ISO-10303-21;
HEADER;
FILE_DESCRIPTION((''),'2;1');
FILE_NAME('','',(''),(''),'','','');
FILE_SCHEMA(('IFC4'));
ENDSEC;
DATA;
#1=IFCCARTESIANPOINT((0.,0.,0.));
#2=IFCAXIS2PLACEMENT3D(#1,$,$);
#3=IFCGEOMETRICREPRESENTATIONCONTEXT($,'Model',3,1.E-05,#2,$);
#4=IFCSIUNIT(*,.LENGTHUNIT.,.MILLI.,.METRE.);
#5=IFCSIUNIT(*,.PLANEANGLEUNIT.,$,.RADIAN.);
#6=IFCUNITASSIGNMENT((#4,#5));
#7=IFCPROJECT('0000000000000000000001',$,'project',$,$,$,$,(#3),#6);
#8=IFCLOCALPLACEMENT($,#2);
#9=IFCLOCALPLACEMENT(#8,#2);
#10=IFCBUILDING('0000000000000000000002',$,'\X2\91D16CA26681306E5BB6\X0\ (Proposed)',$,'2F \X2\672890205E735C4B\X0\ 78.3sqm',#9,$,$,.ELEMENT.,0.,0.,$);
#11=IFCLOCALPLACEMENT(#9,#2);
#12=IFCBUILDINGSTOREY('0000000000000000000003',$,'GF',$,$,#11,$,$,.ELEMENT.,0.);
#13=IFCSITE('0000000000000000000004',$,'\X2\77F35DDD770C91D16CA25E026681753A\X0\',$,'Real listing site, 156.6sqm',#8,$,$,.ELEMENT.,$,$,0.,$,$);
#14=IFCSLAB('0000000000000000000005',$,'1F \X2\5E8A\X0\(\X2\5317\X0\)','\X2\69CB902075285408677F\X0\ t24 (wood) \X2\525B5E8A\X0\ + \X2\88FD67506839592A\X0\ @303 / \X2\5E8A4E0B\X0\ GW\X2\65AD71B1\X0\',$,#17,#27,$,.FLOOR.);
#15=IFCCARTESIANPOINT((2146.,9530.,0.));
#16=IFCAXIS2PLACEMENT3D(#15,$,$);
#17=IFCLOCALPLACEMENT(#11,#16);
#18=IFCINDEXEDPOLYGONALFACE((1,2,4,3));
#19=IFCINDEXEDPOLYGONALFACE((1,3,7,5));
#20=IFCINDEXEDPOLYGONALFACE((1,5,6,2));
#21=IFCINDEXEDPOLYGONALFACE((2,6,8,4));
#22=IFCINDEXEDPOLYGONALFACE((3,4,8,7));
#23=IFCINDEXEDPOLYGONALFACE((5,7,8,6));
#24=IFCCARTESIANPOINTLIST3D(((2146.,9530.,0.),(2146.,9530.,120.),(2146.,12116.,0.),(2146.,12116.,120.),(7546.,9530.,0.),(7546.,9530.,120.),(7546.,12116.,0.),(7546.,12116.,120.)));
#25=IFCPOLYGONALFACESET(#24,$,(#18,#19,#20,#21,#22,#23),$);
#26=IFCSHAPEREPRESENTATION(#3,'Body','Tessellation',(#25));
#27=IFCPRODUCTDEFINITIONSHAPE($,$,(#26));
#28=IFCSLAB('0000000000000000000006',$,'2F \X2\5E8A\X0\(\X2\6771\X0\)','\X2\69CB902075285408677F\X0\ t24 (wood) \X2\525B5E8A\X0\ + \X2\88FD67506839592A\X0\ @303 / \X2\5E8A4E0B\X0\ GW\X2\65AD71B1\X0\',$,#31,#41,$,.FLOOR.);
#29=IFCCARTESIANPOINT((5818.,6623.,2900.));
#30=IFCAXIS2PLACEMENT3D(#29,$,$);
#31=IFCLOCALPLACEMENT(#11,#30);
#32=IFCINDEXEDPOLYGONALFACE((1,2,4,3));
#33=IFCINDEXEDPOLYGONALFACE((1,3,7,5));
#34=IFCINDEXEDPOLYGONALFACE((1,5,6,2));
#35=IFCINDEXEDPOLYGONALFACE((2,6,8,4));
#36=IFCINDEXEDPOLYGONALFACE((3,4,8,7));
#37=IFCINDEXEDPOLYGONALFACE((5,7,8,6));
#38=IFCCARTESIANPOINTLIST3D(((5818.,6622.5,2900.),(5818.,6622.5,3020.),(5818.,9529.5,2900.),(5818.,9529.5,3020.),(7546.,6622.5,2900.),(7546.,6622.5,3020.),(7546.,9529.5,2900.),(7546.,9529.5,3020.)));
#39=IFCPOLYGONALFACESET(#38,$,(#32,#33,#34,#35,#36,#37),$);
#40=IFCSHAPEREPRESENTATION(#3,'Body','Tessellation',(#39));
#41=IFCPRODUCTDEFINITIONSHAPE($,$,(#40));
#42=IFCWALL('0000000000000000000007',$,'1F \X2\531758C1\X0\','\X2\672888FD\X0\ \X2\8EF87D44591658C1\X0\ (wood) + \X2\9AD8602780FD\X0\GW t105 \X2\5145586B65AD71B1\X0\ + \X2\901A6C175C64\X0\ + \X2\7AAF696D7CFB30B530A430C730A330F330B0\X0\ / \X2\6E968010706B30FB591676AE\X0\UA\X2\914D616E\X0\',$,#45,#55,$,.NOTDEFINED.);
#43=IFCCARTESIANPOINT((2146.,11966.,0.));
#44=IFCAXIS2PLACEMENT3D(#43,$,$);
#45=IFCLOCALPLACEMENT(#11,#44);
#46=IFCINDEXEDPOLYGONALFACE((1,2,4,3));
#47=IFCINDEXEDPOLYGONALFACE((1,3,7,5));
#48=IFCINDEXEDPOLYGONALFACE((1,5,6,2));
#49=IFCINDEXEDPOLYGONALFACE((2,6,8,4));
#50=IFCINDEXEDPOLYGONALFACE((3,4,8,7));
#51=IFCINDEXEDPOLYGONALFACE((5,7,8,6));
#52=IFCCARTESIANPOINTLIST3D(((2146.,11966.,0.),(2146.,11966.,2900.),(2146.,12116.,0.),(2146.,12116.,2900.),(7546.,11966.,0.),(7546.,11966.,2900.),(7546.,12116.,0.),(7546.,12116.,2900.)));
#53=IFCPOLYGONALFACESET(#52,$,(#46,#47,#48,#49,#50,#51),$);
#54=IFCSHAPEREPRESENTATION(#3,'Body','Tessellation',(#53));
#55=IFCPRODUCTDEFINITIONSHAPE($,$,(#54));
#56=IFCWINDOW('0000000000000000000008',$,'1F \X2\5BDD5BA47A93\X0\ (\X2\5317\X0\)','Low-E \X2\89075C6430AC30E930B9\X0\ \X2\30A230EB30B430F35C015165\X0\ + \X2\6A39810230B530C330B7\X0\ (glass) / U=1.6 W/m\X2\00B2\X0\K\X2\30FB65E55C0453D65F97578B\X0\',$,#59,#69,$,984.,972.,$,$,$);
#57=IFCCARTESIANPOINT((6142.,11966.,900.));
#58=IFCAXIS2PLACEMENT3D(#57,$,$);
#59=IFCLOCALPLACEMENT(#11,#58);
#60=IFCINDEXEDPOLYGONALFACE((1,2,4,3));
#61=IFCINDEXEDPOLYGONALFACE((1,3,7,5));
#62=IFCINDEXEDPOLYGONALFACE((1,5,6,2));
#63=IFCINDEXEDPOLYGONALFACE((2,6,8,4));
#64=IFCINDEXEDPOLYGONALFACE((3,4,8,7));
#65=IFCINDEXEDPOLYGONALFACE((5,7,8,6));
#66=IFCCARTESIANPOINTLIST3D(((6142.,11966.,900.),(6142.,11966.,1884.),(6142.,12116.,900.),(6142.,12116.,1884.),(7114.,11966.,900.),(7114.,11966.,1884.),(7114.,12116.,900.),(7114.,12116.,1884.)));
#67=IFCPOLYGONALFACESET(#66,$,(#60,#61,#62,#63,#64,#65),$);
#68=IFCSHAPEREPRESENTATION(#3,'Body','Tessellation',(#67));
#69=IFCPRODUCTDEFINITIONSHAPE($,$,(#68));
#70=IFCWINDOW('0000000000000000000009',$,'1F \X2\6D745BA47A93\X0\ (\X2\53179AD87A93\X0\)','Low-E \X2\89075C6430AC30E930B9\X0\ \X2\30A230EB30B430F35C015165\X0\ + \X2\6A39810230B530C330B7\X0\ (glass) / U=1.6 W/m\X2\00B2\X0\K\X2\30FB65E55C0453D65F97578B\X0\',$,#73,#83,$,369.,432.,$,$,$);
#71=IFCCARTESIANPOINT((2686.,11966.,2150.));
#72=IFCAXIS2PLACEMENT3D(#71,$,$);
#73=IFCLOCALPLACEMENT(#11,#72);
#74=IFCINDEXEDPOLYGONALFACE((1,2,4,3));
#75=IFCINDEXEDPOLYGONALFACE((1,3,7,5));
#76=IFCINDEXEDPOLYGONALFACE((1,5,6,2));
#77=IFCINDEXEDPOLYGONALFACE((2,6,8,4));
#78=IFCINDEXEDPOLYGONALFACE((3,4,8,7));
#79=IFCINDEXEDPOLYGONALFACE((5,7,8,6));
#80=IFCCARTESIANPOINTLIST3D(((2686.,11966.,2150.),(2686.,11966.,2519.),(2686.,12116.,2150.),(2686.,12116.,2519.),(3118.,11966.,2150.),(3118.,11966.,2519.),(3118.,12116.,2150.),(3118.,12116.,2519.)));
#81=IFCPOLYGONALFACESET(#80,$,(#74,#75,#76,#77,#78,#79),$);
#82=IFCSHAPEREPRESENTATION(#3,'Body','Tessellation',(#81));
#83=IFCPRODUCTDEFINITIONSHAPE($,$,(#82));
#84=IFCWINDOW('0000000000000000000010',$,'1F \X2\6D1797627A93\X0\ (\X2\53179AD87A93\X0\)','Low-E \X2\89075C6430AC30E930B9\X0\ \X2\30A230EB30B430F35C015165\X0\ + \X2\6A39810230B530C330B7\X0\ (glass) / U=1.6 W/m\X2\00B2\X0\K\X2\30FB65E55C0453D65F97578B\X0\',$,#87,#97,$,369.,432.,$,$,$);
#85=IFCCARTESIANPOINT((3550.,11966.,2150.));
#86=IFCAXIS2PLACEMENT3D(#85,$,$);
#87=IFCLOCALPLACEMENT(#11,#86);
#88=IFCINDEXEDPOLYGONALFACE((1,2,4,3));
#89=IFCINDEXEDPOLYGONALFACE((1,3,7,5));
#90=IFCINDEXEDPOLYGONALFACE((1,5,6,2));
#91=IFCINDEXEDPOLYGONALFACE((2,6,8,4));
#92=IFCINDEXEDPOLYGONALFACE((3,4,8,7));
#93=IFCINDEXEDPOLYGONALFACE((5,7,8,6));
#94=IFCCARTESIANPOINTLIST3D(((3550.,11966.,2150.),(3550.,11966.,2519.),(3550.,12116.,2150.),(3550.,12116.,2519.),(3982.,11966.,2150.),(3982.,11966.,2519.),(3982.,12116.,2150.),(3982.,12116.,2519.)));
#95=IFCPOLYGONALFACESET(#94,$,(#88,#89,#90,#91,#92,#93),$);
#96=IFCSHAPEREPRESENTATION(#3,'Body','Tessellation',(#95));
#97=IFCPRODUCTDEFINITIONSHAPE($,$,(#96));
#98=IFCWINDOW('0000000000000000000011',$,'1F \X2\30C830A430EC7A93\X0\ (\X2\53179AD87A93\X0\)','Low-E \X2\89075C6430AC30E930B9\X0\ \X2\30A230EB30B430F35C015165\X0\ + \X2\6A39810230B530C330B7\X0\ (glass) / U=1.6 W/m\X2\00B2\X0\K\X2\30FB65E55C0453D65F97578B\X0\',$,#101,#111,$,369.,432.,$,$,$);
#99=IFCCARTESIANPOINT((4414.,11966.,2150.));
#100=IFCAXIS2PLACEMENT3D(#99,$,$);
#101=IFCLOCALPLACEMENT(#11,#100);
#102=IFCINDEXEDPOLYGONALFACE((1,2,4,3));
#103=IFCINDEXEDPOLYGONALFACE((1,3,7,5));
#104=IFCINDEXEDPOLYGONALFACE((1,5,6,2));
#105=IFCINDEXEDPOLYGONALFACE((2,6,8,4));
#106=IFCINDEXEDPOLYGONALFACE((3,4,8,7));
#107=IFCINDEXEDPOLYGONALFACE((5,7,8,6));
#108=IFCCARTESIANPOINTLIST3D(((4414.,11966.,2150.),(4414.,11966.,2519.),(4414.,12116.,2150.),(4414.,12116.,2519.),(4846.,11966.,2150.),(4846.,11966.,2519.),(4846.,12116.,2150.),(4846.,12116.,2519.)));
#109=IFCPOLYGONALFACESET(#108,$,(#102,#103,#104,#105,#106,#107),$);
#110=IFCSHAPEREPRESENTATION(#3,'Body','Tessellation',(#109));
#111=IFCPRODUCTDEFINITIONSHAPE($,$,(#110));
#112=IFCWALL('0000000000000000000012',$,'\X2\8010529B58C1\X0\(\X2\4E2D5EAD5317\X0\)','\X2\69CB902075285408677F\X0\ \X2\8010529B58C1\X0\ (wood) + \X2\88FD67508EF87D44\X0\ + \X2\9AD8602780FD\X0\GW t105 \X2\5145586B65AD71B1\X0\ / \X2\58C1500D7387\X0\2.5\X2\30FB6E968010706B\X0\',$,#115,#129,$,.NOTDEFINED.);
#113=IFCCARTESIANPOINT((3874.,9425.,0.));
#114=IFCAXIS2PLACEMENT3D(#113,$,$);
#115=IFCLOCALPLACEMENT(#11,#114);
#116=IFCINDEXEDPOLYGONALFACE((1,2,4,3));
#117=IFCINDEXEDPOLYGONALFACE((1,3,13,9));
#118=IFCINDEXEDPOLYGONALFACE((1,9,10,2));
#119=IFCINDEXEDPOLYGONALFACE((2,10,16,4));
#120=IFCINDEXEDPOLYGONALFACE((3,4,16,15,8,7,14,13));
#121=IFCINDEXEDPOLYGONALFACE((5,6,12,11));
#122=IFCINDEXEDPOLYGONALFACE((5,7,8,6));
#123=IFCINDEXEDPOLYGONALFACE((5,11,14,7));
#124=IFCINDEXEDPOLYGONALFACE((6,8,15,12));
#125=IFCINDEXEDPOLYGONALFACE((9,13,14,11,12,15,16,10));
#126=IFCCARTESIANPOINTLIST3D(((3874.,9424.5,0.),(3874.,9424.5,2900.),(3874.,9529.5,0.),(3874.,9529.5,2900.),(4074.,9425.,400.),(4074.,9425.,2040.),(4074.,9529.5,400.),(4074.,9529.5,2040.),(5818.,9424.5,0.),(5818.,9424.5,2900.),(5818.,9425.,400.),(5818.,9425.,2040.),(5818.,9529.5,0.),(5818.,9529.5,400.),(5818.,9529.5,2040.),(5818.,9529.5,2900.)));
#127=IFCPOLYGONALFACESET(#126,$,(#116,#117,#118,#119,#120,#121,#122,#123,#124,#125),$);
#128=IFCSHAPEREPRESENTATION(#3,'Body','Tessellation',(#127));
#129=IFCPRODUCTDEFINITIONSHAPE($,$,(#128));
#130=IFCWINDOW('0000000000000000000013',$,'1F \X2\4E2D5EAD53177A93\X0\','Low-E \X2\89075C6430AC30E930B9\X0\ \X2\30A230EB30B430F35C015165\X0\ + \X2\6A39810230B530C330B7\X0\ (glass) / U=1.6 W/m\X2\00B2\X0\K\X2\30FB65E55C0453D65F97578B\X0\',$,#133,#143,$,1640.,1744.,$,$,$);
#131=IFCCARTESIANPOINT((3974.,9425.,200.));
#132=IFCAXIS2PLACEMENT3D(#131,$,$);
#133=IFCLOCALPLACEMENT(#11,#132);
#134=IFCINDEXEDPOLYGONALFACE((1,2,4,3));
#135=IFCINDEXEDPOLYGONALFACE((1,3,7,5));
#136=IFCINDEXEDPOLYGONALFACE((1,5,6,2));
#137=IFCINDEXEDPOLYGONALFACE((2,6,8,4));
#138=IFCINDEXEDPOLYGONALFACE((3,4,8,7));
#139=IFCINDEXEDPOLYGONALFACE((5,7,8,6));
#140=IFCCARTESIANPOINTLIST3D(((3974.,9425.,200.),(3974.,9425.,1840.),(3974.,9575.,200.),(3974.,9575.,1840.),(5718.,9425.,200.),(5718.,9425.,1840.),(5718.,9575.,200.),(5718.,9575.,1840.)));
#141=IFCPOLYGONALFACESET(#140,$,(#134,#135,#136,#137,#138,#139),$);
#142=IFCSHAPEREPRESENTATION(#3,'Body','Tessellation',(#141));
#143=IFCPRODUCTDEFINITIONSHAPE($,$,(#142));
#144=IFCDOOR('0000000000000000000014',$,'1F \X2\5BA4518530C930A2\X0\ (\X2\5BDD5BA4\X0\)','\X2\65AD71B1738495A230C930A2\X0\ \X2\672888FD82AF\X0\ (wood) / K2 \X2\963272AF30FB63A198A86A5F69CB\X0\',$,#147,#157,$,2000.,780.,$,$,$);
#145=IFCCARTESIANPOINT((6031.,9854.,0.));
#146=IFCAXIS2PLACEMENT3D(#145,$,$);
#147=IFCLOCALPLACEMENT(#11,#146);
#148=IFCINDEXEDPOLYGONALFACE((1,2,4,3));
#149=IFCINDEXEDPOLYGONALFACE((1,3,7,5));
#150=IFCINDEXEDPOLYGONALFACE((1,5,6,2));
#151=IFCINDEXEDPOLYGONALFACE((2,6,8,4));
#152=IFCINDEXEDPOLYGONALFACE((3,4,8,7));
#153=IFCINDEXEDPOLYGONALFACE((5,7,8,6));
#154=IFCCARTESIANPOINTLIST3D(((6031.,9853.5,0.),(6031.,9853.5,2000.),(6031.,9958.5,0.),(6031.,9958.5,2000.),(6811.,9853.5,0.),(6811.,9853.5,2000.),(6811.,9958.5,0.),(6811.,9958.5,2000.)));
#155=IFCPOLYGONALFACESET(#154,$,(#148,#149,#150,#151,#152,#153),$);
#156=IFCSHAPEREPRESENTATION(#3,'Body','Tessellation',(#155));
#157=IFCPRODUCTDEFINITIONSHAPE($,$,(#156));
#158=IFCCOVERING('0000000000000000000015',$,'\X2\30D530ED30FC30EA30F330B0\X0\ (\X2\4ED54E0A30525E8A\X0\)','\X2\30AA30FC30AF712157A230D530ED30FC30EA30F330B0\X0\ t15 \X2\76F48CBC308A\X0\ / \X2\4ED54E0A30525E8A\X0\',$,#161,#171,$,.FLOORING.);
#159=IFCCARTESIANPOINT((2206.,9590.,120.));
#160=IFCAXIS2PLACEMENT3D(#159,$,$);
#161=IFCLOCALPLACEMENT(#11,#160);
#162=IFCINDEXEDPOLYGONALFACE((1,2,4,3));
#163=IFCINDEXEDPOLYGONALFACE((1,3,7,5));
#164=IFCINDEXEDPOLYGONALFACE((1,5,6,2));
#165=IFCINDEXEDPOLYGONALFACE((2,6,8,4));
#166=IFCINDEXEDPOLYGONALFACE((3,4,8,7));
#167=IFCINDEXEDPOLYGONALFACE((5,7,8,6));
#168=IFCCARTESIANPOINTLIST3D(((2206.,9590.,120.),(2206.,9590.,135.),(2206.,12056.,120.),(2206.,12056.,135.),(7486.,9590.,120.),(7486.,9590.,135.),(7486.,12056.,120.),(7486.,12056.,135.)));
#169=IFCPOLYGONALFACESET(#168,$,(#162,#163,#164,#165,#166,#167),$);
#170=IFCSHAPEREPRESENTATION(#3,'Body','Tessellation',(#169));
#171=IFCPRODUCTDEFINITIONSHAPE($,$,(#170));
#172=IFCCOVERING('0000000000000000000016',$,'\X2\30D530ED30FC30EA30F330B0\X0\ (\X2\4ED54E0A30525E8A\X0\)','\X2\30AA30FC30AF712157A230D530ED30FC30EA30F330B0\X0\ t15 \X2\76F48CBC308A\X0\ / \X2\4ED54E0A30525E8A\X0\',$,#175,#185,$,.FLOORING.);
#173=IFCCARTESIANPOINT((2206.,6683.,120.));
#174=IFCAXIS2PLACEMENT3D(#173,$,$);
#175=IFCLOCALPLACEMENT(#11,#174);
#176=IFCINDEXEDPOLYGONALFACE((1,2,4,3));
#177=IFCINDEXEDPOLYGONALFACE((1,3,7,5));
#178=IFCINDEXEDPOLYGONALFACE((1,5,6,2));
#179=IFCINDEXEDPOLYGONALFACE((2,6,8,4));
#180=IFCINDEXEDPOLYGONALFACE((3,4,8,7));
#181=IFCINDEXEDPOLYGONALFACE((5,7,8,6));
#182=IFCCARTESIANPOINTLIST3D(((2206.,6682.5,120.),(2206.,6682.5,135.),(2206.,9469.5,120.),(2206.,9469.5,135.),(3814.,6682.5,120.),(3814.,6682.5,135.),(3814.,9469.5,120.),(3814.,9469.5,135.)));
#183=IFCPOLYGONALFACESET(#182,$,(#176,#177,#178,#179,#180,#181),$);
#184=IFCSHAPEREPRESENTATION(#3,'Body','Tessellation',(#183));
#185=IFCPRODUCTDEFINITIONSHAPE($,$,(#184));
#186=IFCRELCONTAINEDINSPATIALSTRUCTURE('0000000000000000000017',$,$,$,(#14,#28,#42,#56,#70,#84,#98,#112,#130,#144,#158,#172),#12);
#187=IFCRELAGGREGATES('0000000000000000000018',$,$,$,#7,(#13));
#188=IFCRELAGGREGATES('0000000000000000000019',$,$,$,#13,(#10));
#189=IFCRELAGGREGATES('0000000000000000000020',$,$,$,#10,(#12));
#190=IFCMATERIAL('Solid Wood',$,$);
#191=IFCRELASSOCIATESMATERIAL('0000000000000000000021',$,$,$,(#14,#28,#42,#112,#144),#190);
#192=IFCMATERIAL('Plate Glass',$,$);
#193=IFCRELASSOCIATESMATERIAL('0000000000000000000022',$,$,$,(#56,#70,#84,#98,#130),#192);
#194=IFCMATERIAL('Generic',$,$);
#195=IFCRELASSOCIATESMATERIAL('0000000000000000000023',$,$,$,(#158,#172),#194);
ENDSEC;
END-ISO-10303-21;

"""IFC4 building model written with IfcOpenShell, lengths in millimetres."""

from ifc_helpers import new_model, si_unit, frame, frame_2d, origin, place, context, project, spatial, rectangle, extrude, material, element, fill, save


model = new_model("IFC4")

# Units and contexts
model_context = context("Model", 3, precision=1e-05, world=origin())
ifc_project = project(units=[si_unit("LENGTHUNIT", "METRE", prefix="MILLI"), si_unit("PLANEANGLEUNIT", "RADIAN")], contexts=[model_context])

# Site, building, storey
site_placement = place(None, origin())
site = spatial("IfcSite", under=ifc_project, at=site_placement, Name="石川県金沢市暁町", ObjectType="Real listing site, 156.6sqm", CompositionType="ELEMENT", RefElevation=0.0)
building_placement = place(site_placement, origin())
building = spatial("IfcBuilding", under=site, at=building_placement, Name="金沢暁の家 (Proposed)", ObjectType="2F 木造平屋 78.3sqm", CompositionType="ELEMENT", ElevationOfRefHeight=0.0, ElevationOfTerrain=0.0)
storey_placement = place(building_placement, origin())
storey = spatial("IfcBuildingStorey", under=building, at=storey_placement, Name="GF", CompositionType="ELEMENT", Elevation=0.0)

# Slabs
ifc_material_1 = material(Name="Solid Wood")
slab_1_placement = place(storey_placement, frame((2146.0, 9530.0, 0.0)))
element("IfcSlab", 1, at=slab_1_placement, inside=storey, material=ifc_material_1, Name="1F 床(北)", Description="構造用合板 t24 (wood) 剛床 + 製材根太 @303 / 床下 GW断熱", PredefinedType="FLOOR", context=model_context, shape_type="SweptSolid", body=[
    extrude(rectangle(XDim=5400.0, YDim=2586.0, at=frame_2d((2700.0, 1293.0))), frame((2146.0, 9530.0, 0.0)), (0.0, 0.0, 1.0), 120.0),
])
slab_2_placement = place(storey_placement, frame((5818.0, 6623.0, 2900.0)))
element("IfcSlab", 2, at=slab_2_placement, inside=storey, material=ifc_material_1, Name="2F 床(東)", Description="構造用合板 t24 (wood) 剛床 + 製材根太 @303 / 床下 GW断熱", PredefinedType="FLOOR", context=model_context, shape_type="SweptSolid", body=[
    extrude(rectangle(XDim=1728.0, YDim=2907.0, at=frame_2d((864.0, 1453.0))), frame((5818.0, 6623.0, 2900.0)), (0.0, 0.0, 1.0), 120.0),
])

# Wall, openings, windows
wall_1_placement = place(storey_placement, frame((2146.0, 11966.0, 0.0)))
wall_1 = element("IfcWall", 3, at=wall_1_placement, inside=storey, material=ifc_material_1, Name="1F 北壁", Description="木製 軸組外壁 (wood) + 高性能GW t105 充填断熱 + 通気層 + 窯業系サイディング / 準耐火・外皮UA配慮", PredefinedType="NOTDEFINED", context=model_context, shape_type="SweptSolid", body=[
    extrude(rectangle(XDim=5400.0, YDim=150.0, at=frame_2d((2700.0, 75.0))), frame((2146.0, 11966.0, 0.0)), (0.0, 0.0, 1.0), 2900.0),
])
opening_1_placement = place(storey_placement, frame((6142.0, 11966.0, 900.0)))
opening_1 = element("IfcOpeningElement", 4, at=opening_1_placement, cuts=wall_1, PredefinedType="NOTDEFINED", context=model_context, shape_type="SweptSolid", body=[
    extrude(rectangle(XDim=972.0, YDim=150.0, at=frame_2d((486.0, 75.0))), frame((6142.0, 11966.0, 900.0)), (0.0, 0.0, 1.0), 984.0),
])
opening_2_placement = place(storey_placement, frame((2686.0, 11966.0, 2150.0)))
opening_2 = element("IfcOpeningElement", 5, at=opening_2_placement, cuts=wall_1, PredefinedType="NOTDEFINED", context=model_context, shape_type="SweptSolid", body=[
    extrude(rectangle(XDim=432.0, YDim=150.0, at=frame_2d((216.0, 75.0))), frame((2686.0, 11966.0, 2150.0)), (0.0, 0.0, 1.0), 369.0),
])
opening_3_placement = place(storey_placement, frame((3550.0, 11966.0, 2150.0)))
opening_3 = element("IfcOpeningElement", 6, at=opening_3_placement, cuts=wall_1, PredefinedType="NOTDEFINED", context=model_context, shape_type="SweptSolid", body=[
    extrude(rectangle(XDim=432.0, YDim=150.0, at=frame_2d((216.0, 75.0))), frame((3550.0, 11966.0, 2150.0)), (0.0, 0.0, 1.0), 369.0),
])
opening_4_placement = place(storey_placement, frame((4414.0, 11966.0, 2150.0)))
opening_4 = element("IfcOpeningElement", 7, at=opening_4_placement, cuts=wall_1, PredefinedType="NOTDEFINED", context=model_context, shape_type="SweptSolid", body=[
    extrude(rectangle(XDim=432.0, YDim=150.0, at=frame_2d((216.0, 75.0))), frame((4414.0, 11966.0, 2150.0)), (0.0, 0.0, 1.0), 369.0),
])
ifc_material_2 = material(Name="Plate Glass")
window_1_placement = place(storey_placement, frame((6142.0, 11966.0, 900.0)))
window_1 = element("IfcWindow", 8, at=window_1_placement, inside=storey, material=ifc_material_2, Name="1F 寝室窓 (北)", Description="Low-E 複層ガラス アルゴン封入 + 樹脂サッシ (glass) / U=1.6 W/m²K・日射取得型", OverallHeight=984.0, OverallWidth=972.0, context=model_context, shape_type="SweptSolid", body=[
    extrude(rectangle(XDim=972.0, YDim=150.0, at=frame_2d((486.0, 75.0))), frame((6142.0, 11966.0, 900.0)), (0.0, 0.0, 1.0), 984.0),
])
fill(opening_1, window_1)
window_2_placement = place(storey_placement, frame((2686.0, 11966.0, 2150.0)))
window_2 = element("IfcWindow", 9, at=window_2_placement, inside=storey, material=ifc_material_2, Name="1F 浴室窓 (北高窓)", Description="Low-E 複層ガラス アルゴン封入 + 樹脂サッシ (glass) / U=1.6 W/m²K・日射取得型", OverallHeight=369.0, OverallWidth=432.0, context=model_context, shape_type="SweptSolid", body=[
    extrude(rectangle(XDim=432.0, YDim=150.0, at=frame_2d((216.0, 75.0))), frame((2686.0, 11966.0, 2150.0)), (0.0, 0.0, 1.0), 369.0),
])
fill(opening_2, window_2)
window_3_placement = place(storey_placement, frame((3550.0, 11966.0, 2150.0)))
window_3 = element("IfcWindow", 10, at=window_3_placement, inside=storey, material=ifc_material_2, Name="1F 洗面窓 (北高窓)", Description="Low-E 複層ガラス アルゴン封入 + 樹脂サッシ (glass) / U=1.6 W/m²K・日射取得型", OverallHeight=369.0, OverallWidth=432.0, context=model_context, shape_type="SweptSolid", body=[
    extrude(rectangle(XDim=432.0, YDim=150.0, at=frame_2d((216.0, 75.0))), frame((3550.0, 11966.0, 2150.0)), (0.0, 0.0, 1.0), 369.0),
])
fill(opening_3, window_3)
window_4_placement = place(storey_placement, frame((4414.0, 11966.0, 2150.0)))
window_4 = element("IfcWindow", 11, at=window_4_placement, inside=storey, material=ifc_material_2, Name="1F トイレ窓 (北高窓)", Description="Low-E 複層ガラス アルゴン封入 + 樹脂サッシ (glass) / U=1.6 W/m²K・日射取得型", OverallHeight=369.0, OverallWidth=432.0, context=model_context, shape_type="SweptSolid", body=[
    extrude(rectangle(XDim=432.0, YDim=150.0, at=frame_2d((216.0, 75.0))), frame((4414.0, 11966.0, 2150.0)), (0.0, 0.0, 1.0), 369.0),
])
fill(opening_4, window_4)

# Wall, opening, window
wall_2_placement = place(storey_placement, frame((3874.0, 9425.0, 0.0)))
wall_2 = element("IfcWall", 12, at=wall_2_placement, inside=storey, material=ifc_material_1, Name="耐力壁(中庭北)", Description="構造用合板 耐力壁 (wood) + 製材軸組 + 高性能GW t105 充填断熱 / 壁倍率2.5・準耐火", PredefinedType="NOTDEFINED", context=model_context, shape_type="SweptSolid", body=[
    extrude(rectangle(XDim=1944.0, YDim=105.0, at=frame_2d((972.0, 52.0))), frame((3874.0, 9425.0, 0.0)), (0.0, 0.0, 1.0), 2900.0),
])
opening_5_placement = place(storey_placement, frame((3974.0, 9425.0, 200.0)))
opening_5 = element("IfcOpeningElement", 13, at=opening_5_placement, cuts=wall_2, PredefinedType="NOTDEFINED", context=model_context, shape_type="SweptSolid", body=[
    extrude(rectangle(XDim=1744.0, YDim=150.0, at=frame_2d((872.0, 75.0))), frame((3974.0, 9425.0, 200.0)), (0.0, 0.0, 1.0), 1640.0),
])
window_5_placement = place(storey_placement, frame((3974.0, 9425.0, 200.0)))
window_5 = element("IfcWindow", 14, at=window_5_placement, inside=storey, material=ifc_material_2, Name="1F 中庭北窓", Description="Low-E 複層ガラス アルゴン封入 + 樹脂サッシ (glass) / U=1.6 W/m²K・日射取得型", OverallHeight=1640.0, OverallWidth=1744.0, context=model_context, shape_type="SweptSolid", body=[
    extrude(rectangle(XDim=1744.0, YDim=150.0, at=frame_2d((872.0, 75.0))), frame((3974.0, 9425.0, 200.0)), (0.0, 0.0, 1.0), 1640.0),
])
fill(opening_5, window_5)

# Door
door_1_placement = place(storey_placement, frame((6031.0, 9854.0, 0.0)))
element("IfcDoor", 15, at=door_1_placement, inside=storey, material=ifc_material_1, Name="1F 室内ドア (寝室)", Description="断熱玄関ドア 木製芯 (wood) / K2 防犯・採風機構", OverallHeight=2000.0, OverallWidth=780.0, context=model_context, shape_type="SweptSolid", body=[
    extrude(rectangle(XDim=780.0, YDim=105.0, at=frame_2d((390.0, 52.0))), frame((6031.0, 9854.0, 0.0)), (0.0, 0.0, 1.0), 2000.0),
])

# Coverings
ifc_material_3 = material(Name="Generic")
covering_1_placement = place(storey_placement, frame((2206.0, 9590.0, 120.0)))
element("IfcCovering", 16, at=covering_1_placement, inside=storey, material=ifc_material_3, Name="フローリング (仕上げ床)", Description="オーク無垢フローリング t15 直貼り / 仕上げ床", PredefinedType="FLOORING", context=model_context, shape_type="SweptSolid", body=[
    extrude(rectangle(XDim=5280.0, YDim=2466.0, at=frame_2d((2640.0, 1233.0))), frame((2206.0, 9590.0, 120.0)), (0.0, 0.0, 1.0), 15.0),
])
covering_2_placement = place(storey_placement, frame((2206.0, 6683.0, 120.0)))
element("IfcCovering", 17, at=covering_2_placement, inside=storey, material=ifc_material_3, Name="フローリング (仕上げ床)", Description="オーク無垢フローリング t15 直貼り / 仕上げ床", PredefinedType="FLOORING", context=model_context, shape_type="SweptSolid", body=[
    extrude(rectangle(XDim=1608.0, YDim=2787.0, at=frame_2d((804.0, 1393.0))), frame((2206.0, 6683.0, 120.0)), (0.0, 0.0, 1.0), 15.0),
])

save(model, "model.ifc")
